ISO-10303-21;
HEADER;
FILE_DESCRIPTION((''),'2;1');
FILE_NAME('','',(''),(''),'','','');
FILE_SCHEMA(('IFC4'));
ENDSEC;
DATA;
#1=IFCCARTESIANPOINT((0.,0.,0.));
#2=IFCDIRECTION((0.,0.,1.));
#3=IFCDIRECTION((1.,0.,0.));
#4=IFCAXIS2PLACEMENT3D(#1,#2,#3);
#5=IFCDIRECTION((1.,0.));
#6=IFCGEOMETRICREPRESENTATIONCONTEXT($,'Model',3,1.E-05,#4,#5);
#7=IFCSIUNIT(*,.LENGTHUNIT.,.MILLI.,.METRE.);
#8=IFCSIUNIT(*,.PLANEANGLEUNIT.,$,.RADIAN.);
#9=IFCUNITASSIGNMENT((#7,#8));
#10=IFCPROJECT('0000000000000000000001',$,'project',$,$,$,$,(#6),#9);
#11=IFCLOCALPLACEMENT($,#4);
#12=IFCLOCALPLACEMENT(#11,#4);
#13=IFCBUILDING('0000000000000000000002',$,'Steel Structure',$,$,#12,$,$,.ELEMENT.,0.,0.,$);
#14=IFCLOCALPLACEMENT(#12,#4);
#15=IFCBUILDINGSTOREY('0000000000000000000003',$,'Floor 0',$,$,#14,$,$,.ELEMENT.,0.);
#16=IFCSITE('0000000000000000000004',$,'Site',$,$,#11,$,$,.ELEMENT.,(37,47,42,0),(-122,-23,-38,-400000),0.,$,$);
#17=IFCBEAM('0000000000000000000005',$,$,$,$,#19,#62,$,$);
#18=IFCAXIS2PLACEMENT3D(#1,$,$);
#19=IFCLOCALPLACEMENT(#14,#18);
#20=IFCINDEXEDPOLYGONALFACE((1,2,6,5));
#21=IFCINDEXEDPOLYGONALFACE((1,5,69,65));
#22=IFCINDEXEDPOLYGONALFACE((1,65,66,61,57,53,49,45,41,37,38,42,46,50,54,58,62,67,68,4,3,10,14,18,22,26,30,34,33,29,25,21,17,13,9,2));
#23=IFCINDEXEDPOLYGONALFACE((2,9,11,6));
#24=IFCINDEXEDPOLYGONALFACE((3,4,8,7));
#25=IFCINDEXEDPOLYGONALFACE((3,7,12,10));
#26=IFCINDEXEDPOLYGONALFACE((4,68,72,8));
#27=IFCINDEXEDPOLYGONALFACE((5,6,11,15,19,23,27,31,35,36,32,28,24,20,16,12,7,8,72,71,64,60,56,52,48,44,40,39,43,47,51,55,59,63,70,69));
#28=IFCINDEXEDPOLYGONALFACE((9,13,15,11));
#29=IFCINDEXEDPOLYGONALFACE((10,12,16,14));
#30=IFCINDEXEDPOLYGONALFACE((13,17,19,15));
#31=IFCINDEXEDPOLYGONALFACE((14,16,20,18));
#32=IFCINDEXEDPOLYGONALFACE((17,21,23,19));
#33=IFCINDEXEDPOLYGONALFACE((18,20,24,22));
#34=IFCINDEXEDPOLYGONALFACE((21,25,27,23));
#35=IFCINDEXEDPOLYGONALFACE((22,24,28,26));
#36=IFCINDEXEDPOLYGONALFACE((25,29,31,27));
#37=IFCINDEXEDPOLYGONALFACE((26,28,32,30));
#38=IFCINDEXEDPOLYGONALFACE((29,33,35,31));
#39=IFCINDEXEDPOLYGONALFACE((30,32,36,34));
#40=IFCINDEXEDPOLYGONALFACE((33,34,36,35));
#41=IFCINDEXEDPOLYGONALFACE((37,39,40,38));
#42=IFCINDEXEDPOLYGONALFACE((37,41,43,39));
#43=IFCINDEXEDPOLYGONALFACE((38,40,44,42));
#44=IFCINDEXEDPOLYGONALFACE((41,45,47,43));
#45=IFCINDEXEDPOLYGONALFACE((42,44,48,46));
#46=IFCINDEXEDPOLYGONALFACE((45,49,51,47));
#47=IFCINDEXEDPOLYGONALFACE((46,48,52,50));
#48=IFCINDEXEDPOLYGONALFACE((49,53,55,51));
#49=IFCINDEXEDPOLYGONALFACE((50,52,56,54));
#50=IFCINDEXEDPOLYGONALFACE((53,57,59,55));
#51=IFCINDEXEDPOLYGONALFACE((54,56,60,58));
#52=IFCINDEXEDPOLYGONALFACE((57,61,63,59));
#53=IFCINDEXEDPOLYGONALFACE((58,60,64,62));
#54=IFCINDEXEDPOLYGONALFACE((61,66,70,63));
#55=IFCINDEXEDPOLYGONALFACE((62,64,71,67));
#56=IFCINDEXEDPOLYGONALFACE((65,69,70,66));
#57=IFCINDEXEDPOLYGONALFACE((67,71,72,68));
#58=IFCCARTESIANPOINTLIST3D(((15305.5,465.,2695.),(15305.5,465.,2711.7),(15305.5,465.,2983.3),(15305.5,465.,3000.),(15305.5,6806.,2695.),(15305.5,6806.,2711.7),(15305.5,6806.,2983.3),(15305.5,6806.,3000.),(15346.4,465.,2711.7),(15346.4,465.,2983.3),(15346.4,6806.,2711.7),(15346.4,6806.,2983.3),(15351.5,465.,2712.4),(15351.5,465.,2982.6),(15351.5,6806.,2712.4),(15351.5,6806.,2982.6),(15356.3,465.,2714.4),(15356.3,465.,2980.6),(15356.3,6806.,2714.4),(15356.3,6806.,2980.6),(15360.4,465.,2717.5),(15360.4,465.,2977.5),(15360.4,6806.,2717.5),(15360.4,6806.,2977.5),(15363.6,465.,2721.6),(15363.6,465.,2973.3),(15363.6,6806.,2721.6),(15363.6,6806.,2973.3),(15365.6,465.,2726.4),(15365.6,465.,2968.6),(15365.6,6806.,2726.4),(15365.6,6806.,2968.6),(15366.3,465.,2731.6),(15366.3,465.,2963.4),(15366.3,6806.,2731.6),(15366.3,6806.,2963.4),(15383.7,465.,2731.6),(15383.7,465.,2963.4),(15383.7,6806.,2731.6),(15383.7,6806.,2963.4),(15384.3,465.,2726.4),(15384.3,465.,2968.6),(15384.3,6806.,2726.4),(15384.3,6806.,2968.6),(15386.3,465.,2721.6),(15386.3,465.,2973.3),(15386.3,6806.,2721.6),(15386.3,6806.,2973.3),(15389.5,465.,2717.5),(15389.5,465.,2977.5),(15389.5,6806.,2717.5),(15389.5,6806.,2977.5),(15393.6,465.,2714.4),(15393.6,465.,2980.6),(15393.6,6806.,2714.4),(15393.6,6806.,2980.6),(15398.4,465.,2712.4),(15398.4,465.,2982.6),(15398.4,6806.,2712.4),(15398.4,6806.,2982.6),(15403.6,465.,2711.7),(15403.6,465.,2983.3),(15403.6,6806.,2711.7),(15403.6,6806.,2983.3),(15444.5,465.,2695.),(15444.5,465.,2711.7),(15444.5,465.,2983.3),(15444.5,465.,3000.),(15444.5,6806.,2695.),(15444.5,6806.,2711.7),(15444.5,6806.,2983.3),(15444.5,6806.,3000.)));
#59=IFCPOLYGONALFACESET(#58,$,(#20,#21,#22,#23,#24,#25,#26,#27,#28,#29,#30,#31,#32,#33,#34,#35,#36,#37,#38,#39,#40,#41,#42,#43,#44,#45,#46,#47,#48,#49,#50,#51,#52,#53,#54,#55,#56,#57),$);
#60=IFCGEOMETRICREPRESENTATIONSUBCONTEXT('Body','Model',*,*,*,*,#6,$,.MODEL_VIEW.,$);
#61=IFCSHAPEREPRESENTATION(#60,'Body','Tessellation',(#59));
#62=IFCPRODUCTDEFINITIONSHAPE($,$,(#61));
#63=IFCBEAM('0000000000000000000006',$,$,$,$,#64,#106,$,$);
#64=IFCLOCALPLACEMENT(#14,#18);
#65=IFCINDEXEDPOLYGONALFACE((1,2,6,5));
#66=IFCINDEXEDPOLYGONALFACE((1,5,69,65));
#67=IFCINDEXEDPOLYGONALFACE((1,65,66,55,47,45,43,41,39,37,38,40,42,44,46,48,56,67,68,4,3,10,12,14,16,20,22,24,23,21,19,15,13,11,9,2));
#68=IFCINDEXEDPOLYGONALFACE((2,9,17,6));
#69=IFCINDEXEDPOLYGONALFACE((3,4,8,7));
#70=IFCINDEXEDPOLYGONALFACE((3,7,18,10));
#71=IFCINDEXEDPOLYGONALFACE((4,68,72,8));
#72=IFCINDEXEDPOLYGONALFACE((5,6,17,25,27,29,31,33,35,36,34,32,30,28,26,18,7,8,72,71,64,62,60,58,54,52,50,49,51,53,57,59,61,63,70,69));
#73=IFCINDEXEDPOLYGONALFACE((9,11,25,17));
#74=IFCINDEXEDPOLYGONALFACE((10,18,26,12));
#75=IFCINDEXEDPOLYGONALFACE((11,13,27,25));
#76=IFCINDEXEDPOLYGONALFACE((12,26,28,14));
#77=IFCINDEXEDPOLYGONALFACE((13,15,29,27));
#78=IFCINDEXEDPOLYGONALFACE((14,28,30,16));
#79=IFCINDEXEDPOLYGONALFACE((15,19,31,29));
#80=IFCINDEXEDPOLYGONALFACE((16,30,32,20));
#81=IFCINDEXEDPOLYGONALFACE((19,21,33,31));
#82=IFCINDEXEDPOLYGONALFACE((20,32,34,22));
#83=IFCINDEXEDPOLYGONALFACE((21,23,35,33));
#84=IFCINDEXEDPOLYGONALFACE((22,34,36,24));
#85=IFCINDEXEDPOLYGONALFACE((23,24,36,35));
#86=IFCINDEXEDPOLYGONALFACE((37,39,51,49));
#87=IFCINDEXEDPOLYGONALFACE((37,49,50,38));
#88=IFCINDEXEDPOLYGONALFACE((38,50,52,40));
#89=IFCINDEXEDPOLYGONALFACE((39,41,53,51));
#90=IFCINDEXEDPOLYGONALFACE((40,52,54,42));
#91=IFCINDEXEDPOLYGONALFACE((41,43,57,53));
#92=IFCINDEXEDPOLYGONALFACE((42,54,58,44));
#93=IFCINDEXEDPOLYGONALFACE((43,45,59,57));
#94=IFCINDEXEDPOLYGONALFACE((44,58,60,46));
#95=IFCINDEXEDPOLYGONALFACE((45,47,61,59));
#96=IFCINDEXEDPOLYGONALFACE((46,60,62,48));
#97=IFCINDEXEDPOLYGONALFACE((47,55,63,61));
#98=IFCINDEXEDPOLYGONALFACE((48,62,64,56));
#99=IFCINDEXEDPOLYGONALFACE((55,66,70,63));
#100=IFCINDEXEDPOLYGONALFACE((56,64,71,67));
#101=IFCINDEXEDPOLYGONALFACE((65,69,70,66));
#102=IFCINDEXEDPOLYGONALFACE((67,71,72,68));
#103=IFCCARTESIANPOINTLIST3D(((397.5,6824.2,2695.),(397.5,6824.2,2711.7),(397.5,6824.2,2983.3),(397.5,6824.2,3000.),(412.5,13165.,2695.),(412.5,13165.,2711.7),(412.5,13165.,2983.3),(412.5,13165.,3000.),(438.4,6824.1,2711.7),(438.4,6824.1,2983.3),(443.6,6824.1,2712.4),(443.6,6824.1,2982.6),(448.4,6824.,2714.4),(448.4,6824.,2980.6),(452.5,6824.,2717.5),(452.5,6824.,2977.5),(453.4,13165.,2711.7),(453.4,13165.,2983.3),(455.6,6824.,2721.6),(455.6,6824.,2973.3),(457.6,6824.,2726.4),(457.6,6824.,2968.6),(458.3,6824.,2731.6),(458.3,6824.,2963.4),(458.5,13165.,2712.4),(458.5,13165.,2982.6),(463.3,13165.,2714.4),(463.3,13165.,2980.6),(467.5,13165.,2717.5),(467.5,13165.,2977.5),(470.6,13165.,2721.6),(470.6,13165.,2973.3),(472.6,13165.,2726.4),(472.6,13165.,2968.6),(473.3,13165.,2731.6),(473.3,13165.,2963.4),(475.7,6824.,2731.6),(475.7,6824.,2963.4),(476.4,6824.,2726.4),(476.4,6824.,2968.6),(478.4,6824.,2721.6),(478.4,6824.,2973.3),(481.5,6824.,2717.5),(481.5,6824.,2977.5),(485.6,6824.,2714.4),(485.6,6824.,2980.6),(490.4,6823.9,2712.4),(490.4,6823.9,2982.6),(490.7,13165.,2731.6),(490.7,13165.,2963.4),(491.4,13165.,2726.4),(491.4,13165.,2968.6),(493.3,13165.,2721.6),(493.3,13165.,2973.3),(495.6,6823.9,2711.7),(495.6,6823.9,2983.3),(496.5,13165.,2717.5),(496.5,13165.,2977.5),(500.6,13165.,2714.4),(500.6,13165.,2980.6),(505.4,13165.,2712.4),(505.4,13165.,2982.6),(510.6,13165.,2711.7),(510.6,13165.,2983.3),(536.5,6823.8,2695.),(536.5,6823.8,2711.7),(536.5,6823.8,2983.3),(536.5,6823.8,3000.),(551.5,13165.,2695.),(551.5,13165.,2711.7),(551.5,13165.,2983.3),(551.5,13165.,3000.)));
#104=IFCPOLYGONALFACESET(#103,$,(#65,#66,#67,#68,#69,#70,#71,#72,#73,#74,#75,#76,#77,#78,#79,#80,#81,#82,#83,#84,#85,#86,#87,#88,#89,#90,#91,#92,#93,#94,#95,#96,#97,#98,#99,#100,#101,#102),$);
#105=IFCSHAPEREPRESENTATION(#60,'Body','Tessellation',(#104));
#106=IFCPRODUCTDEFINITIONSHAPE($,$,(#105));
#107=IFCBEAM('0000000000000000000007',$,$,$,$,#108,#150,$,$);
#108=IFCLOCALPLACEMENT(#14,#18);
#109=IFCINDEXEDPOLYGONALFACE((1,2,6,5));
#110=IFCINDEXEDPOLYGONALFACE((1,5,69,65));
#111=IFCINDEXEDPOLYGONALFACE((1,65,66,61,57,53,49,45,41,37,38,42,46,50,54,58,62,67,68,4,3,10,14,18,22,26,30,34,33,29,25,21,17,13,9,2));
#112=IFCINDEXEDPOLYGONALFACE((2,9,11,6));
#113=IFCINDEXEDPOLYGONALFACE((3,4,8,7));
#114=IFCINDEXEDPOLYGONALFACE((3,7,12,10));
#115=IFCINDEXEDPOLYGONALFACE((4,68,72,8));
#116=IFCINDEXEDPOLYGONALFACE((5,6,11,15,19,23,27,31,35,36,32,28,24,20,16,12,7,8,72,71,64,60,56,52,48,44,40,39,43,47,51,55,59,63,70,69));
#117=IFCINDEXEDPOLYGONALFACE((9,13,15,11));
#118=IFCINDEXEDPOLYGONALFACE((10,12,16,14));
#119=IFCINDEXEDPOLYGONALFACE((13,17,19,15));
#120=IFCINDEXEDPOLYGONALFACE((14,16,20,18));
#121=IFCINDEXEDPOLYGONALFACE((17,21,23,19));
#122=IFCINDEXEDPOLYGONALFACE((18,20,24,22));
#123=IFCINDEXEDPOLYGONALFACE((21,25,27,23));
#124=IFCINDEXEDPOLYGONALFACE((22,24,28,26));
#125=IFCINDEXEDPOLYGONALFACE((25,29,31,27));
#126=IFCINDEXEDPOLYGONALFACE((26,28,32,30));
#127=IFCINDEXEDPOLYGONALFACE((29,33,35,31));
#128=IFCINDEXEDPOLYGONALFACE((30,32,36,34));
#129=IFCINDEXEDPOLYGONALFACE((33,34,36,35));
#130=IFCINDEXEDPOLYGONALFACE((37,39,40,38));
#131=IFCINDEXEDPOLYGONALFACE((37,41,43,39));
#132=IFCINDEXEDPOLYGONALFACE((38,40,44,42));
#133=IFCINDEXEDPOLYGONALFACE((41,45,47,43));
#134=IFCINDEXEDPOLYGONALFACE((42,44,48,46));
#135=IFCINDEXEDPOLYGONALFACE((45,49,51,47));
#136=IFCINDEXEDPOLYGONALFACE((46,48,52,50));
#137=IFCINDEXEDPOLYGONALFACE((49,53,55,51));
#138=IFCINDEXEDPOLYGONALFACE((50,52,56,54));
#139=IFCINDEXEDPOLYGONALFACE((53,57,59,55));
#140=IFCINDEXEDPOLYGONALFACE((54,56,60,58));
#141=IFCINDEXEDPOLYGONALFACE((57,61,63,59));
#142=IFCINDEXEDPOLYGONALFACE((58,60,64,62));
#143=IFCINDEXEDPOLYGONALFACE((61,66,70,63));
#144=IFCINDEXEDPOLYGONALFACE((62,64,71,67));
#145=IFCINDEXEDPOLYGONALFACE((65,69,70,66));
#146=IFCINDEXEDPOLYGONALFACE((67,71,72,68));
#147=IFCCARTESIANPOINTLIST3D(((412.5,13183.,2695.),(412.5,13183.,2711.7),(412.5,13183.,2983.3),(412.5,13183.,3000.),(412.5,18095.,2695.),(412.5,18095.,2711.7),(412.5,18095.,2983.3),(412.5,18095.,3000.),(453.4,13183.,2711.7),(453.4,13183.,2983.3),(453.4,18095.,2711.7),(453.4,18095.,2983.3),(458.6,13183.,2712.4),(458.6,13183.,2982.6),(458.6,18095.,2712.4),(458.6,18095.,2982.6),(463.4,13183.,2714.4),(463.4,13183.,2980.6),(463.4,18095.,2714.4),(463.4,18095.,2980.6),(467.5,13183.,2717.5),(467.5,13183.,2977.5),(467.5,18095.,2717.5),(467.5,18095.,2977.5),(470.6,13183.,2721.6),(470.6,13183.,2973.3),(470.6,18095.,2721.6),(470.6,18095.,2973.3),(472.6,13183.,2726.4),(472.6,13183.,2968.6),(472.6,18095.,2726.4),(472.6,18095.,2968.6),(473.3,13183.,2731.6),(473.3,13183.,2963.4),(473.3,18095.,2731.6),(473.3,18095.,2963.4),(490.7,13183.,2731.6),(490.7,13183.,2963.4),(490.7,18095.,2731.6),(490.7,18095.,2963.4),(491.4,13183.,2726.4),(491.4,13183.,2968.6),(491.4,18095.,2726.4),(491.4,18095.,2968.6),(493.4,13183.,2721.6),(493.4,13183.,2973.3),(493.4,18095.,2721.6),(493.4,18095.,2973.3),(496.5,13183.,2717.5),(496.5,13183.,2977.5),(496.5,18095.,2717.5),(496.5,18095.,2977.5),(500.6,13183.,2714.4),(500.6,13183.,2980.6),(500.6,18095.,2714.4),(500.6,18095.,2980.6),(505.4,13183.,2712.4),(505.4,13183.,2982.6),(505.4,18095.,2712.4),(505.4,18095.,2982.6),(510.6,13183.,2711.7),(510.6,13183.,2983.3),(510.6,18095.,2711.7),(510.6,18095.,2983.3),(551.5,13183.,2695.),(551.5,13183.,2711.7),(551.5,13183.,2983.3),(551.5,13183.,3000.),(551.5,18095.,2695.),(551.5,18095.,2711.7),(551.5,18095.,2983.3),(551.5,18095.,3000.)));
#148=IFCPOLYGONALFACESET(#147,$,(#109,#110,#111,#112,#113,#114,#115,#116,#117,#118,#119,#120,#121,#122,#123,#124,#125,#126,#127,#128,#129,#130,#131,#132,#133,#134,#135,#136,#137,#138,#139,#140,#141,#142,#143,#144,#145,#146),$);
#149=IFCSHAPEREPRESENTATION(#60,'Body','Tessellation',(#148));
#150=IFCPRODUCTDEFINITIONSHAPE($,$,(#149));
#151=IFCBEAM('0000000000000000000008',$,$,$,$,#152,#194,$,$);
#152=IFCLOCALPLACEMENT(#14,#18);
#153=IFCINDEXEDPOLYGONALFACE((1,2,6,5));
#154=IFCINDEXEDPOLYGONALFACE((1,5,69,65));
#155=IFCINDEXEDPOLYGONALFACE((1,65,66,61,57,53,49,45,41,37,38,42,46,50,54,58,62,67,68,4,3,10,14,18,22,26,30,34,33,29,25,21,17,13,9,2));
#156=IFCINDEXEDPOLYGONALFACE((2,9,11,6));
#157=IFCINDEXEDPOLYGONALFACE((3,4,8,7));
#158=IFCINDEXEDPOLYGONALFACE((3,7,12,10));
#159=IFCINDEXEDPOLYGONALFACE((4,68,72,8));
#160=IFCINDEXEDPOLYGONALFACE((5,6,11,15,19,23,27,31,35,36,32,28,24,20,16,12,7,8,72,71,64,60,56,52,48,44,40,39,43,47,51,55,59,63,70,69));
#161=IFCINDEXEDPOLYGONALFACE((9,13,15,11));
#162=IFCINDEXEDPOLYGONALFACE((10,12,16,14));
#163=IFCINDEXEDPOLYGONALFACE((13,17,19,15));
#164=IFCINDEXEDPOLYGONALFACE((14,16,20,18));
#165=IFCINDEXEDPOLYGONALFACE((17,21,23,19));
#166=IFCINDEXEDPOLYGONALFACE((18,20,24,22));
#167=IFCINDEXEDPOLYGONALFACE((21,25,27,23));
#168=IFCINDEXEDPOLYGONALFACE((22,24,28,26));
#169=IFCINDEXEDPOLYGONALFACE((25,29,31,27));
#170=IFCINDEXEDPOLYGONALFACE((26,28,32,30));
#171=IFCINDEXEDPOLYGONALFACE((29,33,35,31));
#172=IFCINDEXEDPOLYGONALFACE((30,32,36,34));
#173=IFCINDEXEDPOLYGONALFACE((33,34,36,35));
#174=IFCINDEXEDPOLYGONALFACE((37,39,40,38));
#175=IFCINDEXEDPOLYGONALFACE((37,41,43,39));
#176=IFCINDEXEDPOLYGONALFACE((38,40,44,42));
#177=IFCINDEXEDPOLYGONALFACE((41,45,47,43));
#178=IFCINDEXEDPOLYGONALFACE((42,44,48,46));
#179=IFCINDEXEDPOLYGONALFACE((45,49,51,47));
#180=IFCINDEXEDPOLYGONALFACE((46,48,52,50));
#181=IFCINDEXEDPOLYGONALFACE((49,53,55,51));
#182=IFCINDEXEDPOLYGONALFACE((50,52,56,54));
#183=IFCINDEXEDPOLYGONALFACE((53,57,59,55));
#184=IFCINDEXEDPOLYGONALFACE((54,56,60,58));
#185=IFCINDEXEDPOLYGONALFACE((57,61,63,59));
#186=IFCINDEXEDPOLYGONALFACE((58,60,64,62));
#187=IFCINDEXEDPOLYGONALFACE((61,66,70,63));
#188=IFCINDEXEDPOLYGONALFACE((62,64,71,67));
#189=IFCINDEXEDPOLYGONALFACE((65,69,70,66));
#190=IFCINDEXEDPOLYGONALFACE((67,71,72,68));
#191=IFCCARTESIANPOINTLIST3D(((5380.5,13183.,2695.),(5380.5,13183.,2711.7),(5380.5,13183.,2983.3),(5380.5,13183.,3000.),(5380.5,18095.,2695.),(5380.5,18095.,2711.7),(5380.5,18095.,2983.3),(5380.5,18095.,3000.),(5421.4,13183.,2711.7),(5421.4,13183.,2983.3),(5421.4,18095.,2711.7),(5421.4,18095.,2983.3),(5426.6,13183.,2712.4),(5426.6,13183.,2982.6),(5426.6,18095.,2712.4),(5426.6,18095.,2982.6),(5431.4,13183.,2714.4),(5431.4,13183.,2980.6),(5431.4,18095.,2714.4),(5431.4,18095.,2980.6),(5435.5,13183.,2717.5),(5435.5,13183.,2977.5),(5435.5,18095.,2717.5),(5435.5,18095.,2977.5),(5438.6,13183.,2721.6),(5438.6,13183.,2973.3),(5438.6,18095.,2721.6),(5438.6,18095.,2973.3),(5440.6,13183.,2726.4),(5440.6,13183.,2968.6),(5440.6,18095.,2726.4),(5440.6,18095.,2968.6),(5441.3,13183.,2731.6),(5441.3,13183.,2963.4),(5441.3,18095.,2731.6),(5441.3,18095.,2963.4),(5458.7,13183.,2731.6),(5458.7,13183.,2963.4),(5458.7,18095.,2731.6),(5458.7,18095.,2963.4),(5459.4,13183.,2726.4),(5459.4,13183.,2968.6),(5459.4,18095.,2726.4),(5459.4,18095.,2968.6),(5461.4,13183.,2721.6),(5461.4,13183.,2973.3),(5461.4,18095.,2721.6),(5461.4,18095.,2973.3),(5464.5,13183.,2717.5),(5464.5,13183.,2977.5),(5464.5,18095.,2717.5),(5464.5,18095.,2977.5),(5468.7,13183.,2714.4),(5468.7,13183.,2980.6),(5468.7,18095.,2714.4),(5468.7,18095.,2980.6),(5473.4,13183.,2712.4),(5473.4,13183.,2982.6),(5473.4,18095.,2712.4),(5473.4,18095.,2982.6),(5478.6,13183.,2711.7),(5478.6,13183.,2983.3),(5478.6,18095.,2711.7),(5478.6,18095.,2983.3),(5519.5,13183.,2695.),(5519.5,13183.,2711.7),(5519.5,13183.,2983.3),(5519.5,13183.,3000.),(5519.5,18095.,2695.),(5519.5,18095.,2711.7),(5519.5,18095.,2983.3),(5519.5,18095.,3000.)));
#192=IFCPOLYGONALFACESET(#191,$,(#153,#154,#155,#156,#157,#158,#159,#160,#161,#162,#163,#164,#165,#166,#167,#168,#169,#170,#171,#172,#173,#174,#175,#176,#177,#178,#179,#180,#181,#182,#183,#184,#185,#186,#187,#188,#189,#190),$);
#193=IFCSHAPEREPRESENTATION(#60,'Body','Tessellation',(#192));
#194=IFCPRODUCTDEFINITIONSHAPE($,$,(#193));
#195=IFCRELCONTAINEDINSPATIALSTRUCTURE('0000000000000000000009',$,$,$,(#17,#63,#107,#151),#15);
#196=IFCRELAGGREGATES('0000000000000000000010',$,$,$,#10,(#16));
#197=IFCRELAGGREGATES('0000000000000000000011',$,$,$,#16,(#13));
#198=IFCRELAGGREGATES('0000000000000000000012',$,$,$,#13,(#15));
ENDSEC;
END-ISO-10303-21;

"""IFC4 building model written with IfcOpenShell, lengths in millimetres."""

from ifc_helpers import new_model, si_unit, direction, frame, origin_with_axes, origin_2d_with_axis, place, context, subcontext, project, spatial, polyline, i_section, extrude, clip, bounded_halfspace, element, save


model = new_model("IFC4")

# Units and contexts
model_context = context("Model", 3, precision=1e-05, world=origin_with_axes(), true_north=direction((1.0, 0.0)))
body_context = subcontext(model_context, "Body", "Model", "MODEL_VIEW")
ifc_project = project(units=[si_unit("LENGTHUNIT", "METRE", prefix="MILLI"), si_unit("PLANEANGLEUNIT", "RADIAN")], contexts=[model_context])

# Site, building, storey
site_placement = place(None, origin_with_axes())
site = spatial("IfcSite", under=ifc_project, at=site_placement, Name="Site", CompositionType="ELEMENT", RefLatitude=(37, 47, 42, 0), RefLongitude=(-122, -23, -38, -400000), RefElevation=0.0)
building_placement = place(site_placement, origin_with_axes())
building = spatial("IfcBuilding", under=site, at=building_placement, Name="Steel Structure", CompositionType="ELEMENT", ElevationOfRefHeight=0.0, ElevationOfTerrain=0.0)
storey_placement = place(building_placement, origin_with_axes())
storey = spatial("IfcBuildingStorey", under=building, at=storey_placement, Name="Floor 0", CompositionType="ELEMENT", Elevation=0.0)

# Beams
beam_1_placement = place(storey_placement, frame((15375.0, 465.0, 2847.5), z_axis=(0.0, 1.0, 0.0), x_axis=(-1.0, 0.0, 0.0)))
element("IfcBeam", 1, at=beam_1_placement, inside=storey, context=body_context, shape_type="SweptSolid", body=[
    extrude(i_section(OverallWidth=139.0, OverallDepth=305.0, WebThickness=17.4, FlangeThickness=16.7, FilletRadius=19.9, at=origin_2d_with_axis()), origin_with_axes(), (0.0, 0.0, 1.0), 6341.0),
])
beam_2_placement = place(storey_placement, frame((482.0, 13165.2, 2695.0), z_axis=(-0.002362, -0.999997, 0.0), x_axis=(0.999997, -0.002362, 0.0)))
element("IfcBeam", 2, at=beam_2_placement, inside=storey, context=body_context, shape_type="Clipping", body=[
    clip(extrude(i_section(OverallWidth=139.0, OverallDepth=305.0, WebThickness=17.4, FlangeThickness=16.7, FilletRadius=19.9, at=origin_2d_with_axis()), frame((0.0, 152.5, 0.0), z_axis=(0.0, 0.0, 1.0), x_axis=(1.0, 0.0, 0.0)), (0.0, 0.0, 1.0), 6341.2), bounded_halfspace(frame((-482.0, -2695.0, 1.3), z_axis=(-0.002362, 0.0, -0.999997), x_axis=(-0.999997, 0.0, 0.002362)), False, frame((0.0, 152.5, 0.0), z_axis=(0.0, 0.0, 1.0), x_axis=(1.0, 0.0, 0.0)), polyline([(69.5, 152.5), (69.5, 135.8), (28.6, 135.8), (8.7, 115.9), (8.7, -115.9), (28.6, -135.8), (69.5, -135.8), (69.5, -152.5), (-69.5, -152.5), (-69.5, -135.8), (-28.6, -135.8), (-8.7, -115.9), (-8.7, 115.9), (-28.6, 135.8), (-69.5, 135.8), (-69.5, 152.5), (69.5, 152.5)]))),
])
beam_3_placement = place(storey_placement, frame((482.0, 13183.0, 2695.0), z_axis=(0.0, 1.0, 0.0), x_axis=(-1.0, 0.0, 0.0)))
element("IfcBeam", 3, at=beam_3_placement, inside=storey, context=body_context, shape_type="SweptSolid", body=[
    extrude(i_section(OverallWidth=139.0, OverallDepth=305.0, WebThickness=17.4, FlangeThickness=16.7, FilletRadius=19.9, at=origin_2d_with_axis()), frame((0.0, 152.5, 0.0), z_axis=(0.0, 0.0, 1.0), x_axis=(1.0, 0.0, 0.0)), (0.0, 0.0, 1.0), 4912.0),
])
beam_4_placement = place(storey_placement, frame((5450.0, 13183.0, 2695.0), z_axis=(0.0, 1.0, 0.0), x_axis=(-1.0, 0.0, 0.0)))
element("IfcBeam", 4, at=beam_4_placement, inside=storey, context=body_context, shape_type="SweptSolid", body=[
    extrude(i_section(OverallWidth=139.0, OverallDepth=305.0, WebThickness=17.4, FlangeThickness=16.7, FilletRadius=19.9, at=origin_2d_with_axis()), frame((0.0, 152.5, 0.0), z_axis=(0.0, 0.0, 1.0), x_axis=(1.0, 0.0, 0.0)), (0.0, 0.0, 1.0), 4912.0),
])

save(model, "model.ifc")
